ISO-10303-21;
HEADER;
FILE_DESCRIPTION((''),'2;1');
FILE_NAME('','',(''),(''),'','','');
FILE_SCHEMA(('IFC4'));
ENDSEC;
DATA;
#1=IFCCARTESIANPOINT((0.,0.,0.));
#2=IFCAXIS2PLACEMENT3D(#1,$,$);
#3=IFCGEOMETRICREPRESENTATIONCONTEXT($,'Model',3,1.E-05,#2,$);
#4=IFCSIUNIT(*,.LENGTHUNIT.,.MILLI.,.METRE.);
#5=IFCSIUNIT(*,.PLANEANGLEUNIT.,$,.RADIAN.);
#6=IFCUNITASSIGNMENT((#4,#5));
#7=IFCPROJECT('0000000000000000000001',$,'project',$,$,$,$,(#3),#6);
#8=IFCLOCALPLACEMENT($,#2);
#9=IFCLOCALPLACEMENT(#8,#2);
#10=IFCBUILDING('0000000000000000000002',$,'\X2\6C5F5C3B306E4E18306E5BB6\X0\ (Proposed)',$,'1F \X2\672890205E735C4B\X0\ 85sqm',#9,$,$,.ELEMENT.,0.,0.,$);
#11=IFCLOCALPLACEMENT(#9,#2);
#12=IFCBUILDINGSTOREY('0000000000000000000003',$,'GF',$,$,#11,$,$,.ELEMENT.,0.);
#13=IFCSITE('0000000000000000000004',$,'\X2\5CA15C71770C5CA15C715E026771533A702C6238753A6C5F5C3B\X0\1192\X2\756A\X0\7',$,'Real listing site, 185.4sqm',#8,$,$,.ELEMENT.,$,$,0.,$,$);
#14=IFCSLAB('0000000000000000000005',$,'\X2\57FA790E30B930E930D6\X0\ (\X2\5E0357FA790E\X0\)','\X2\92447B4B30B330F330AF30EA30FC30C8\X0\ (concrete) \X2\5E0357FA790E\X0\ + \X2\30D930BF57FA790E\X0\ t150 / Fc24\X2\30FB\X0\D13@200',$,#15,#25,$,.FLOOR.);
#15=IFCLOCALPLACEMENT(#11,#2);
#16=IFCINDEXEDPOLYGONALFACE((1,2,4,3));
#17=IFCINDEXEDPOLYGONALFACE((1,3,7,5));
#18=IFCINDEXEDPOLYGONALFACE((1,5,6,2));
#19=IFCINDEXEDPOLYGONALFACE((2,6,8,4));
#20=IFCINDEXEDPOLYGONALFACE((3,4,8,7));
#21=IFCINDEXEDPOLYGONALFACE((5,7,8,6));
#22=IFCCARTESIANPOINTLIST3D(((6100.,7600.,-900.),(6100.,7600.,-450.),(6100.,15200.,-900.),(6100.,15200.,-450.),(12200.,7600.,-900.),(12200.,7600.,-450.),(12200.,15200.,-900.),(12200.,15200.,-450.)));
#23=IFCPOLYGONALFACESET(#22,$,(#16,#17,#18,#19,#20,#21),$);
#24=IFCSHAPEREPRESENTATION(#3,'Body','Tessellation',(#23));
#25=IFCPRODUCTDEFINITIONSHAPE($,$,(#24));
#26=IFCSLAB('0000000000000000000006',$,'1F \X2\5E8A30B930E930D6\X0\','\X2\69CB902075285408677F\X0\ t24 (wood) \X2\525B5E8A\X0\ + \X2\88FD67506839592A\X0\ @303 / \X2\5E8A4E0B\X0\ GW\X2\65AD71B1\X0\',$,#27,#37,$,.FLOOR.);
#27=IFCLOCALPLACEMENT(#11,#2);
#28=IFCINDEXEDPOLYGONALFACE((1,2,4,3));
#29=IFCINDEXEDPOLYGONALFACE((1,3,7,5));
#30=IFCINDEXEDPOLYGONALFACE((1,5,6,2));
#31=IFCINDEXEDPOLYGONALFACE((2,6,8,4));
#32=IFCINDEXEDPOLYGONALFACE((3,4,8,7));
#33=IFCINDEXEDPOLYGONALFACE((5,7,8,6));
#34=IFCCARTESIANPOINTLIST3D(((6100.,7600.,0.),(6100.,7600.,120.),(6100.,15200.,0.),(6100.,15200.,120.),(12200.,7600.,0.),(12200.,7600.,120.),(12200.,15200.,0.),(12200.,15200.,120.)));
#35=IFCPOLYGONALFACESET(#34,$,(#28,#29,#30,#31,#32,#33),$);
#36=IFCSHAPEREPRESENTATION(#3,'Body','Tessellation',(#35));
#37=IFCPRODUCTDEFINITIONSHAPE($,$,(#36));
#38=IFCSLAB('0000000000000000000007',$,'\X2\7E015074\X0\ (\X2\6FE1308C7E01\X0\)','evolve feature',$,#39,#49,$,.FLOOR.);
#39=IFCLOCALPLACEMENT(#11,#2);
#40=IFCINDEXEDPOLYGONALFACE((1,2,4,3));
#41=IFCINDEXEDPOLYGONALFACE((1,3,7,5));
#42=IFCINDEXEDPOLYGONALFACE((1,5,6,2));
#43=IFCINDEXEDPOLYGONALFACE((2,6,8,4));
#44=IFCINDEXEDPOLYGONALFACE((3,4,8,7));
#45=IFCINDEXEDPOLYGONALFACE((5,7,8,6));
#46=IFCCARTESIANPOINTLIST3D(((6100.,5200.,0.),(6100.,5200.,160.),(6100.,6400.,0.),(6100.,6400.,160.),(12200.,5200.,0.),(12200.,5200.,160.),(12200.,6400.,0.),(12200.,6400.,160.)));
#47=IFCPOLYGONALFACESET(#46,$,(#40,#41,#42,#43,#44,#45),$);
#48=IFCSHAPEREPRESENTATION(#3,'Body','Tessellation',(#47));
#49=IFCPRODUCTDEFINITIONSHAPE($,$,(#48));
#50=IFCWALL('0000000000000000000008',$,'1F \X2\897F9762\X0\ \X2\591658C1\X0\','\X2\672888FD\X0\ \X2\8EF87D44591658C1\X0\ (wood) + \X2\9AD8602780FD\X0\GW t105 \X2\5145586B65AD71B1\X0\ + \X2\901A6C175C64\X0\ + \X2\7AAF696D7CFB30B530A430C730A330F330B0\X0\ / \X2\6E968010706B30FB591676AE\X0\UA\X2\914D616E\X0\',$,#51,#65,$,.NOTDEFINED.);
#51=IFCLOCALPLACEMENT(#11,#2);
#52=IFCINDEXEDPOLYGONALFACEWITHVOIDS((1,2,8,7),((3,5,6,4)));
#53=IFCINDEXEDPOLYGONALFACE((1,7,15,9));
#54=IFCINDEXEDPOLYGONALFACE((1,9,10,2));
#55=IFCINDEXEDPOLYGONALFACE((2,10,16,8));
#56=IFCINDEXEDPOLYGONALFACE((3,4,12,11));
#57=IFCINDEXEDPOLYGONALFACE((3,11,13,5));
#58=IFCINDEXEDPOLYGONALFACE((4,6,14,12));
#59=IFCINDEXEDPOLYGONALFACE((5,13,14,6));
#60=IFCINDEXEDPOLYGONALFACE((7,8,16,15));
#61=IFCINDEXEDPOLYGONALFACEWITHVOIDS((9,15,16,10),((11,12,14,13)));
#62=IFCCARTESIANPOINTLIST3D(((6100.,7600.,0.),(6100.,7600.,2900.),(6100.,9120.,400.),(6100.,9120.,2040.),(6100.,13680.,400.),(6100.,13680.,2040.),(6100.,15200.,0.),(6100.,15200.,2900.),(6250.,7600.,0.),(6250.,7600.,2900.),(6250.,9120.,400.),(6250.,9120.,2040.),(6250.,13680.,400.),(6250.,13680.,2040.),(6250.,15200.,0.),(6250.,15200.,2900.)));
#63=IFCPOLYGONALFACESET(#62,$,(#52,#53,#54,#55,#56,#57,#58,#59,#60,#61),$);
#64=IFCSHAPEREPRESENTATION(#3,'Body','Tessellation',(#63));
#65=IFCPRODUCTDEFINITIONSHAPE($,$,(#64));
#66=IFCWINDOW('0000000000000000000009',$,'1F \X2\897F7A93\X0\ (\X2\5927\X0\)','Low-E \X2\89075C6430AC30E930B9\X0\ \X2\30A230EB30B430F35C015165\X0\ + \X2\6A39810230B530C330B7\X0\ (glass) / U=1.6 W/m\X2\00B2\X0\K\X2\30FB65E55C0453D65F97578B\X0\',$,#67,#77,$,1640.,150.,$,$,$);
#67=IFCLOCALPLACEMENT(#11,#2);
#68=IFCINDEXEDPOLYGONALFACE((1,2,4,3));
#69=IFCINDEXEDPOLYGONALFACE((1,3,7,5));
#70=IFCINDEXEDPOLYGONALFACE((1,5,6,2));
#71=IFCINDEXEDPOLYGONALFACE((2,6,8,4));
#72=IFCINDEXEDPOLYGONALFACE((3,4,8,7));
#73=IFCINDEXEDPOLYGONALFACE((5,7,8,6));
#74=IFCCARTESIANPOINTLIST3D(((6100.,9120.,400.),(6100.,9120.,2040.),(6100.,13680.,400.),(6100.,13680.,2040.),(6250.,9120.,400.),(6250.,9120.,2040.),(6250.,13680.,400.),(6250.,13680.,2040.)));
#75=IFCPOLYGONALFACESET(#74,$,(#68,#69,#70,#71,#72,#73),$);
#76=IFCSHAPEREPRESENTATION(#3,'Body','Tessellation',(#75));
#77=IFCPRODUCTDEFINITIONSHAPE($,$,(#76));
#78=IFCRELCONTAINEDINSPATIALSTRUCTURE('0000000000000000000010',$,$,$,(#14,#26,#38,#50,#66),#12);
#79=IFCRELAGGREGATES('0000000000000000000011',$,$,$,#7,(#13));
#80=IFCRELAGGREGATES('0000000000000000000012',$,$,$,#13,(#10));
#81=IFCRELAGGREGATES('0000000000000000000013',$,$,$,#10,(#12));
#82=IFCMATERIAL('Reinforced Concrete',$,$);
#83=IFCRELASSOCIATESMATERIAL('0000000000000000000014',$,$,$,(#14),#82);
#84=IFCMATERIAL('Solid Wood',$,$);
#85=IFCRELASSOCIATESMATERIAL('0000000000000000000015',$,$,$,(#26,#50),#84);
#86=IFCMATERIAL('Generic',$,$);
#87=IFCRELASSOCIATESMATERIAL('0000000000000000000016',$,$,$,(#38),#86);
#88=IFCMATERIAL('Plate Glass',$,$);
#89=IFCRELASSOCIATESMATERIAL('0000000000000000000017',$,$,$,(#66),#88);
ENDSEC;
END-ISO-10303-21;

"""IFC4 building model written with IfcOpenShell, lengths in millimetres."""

from ifc_helpers import new_model, si_unit, frame, frame_2d, origin, place, context, project, spatial, rectangle, extrude, material, element, fill, save


model = new_model("IFC4")

# Units and contexts
model_context = context("Model", 3, precision=1e-05, world=origin())
ifc_project = project(units=[si_unit("LENGTHUNIT", "METRE", prefix="MILLI"), si_unit("PLANEANGLEUNIT", "RADIAN")], contexts=[model_context])

# Site, building, storey
site_placement = place(None, origin())
site = spatial("IfcSite", under=ifc_project, at=site_placement, Name="岡山県岡山市東区瀬戸町江尻1192番7", ObjectType="Real listing site, 185.4sqm", CompositionType="ELEMENT", RefElevation=0.0)
building_placement = place(site_placement, origin())
building = spatial("IfcBuilding", under=site, at=building_placement, Name="江尻の丘の家 (Proposed)", ObjectType="1F 木造平屋 85sqm", CompositionType="ELEMENT", ElevationOfRefHeight=0.0, ElevationOfTerrain=0.0)
storey_placement = place(building_placement, origin())
storey = spatial("IfcBuildingStorey", under=building, at=storey_placement, Name="GF", CompositionType="ELEMENT", Elevation=0.0)

# Slabs
ifc_material_1 = material(Name="Reinforced Concrete")
slab_1_placement = place(storey_placement, frame((3050.0, 3800.0, -450.0)))
element("IfcSlab", 1, at=slab_1_placement, inside=storey, material=ifc_material_1, Name="基礎スラブ (布基礎)", Description="鉄筋コンクリート (concrete) 布基礎 + ベタ基礎 t150 / Fc24・D13@200", PredefinedType="FLOOR", context=model_context, shape_type="SweptSolid", body=[
    extrude(rectangle(XDim=6100.0, YDim=7600.0, at=frame_2d((3050.0, 3800.0))), frame((3050.0, 3800.0, -450.0)), (0.0, 0.0, 1.0), 450.0),
])
ifc_material_2 = material(Name="Solid Wood")
slab_2_placement = place(storey_placement, frame((3050.0, 3800.0, 0.0)))
element("IfcSlab", 2, at=slab_2_placement, inside=storey, material=ifc_material_2, Name="1F 床スラブ", Description="構造用合板 t24 (wood) 剛床 + 製材根太 @303 / 床下 GW断熱", PredefinedType="FLOOR", context=model_context, shape_type="SweptSolid", body=[
    extrude(rectangle(XDim=6100.0, YDim=7600.0, at=frame_2d((3050.0, 3800.0))), frame((3050.0, 3800.0, 0.0)), (0.0, 0.0, 1.0), 120.0),
])
ifc_material_3 = material(Name="Generic")
slab_3_placement = place(storey_placement, frame((3050.0, 2600.0, 0.0)))
element("IfcSlab", 3, at=slab_3_placement, inside=storey, material=ifc_material_3, Name="縁側 (濡れ縁)", Description="evolve feature", PredefinedType="FLOOR", context=model_context, shape_type="SweptSolid", body=[
    extrude(rectangle(XDim=6100.0, YDim=1200.0, at=frame_2d((3050.0, 600.0))), frame((3050.0, 2600.0, 0.0)), (0.0, 0.0, 1.0), 160.0),
])

# Shared definitions
ifc_material_4 = material(Name="Plate Glass")

# Wall, opening, window
wall_1_placement = place(storey_placement, frame((3050.0, 3800.0, 0.0)))
wall_1 = element("IfcWall", 4, at=wall_1_placement, inside=storey, material=ifc_material_2, Name="1F 西面 外壁", Description="木製 軸組外壁 (wood) + 高性能GW t105 充填断熱 + 通気層 + 窯業系サイディング / 準耐火・外皮UA配慮", PredefinedType="NOTDEFINED", context=model_context, shape_type="SweptSolid", body=[
    extrude(rectangle(XDim=150.0, YDim=7600.0, at=frame_2d((75.0, 3800.0))), frame((3050.0, 3800.0, 0.0)), (0.0, 0.0, 1.0), 2900.0),
])
opening_1_placement = place(storey_placement, frame((3050.0, 4560.0, 200.0)))
opening_1 = element("IfcOpeningElement", 5, at=opening_1_placement, cuts=wall_1, PredefinedType="NOTDEFINED", context=model_context, shape_type="SweptSolid", body=[
    extrude(rectangle(XDim=150.0, YDim=4560.0, at=frame_2d((75.0, 2280.0))), frame((3050.0, 4560.0, 200.0)), (0.0, 0.0, 1.0), 1640.0),
])
window_1_placement = place(storey_placement, frame((3050.0, 4560.0, 200.0)))
window_1 = element("IfcWindow", 6, at=window_1_placement, inside=storey, material=ifc_material_4, Name="1F 西窓 (大)", Description="Low-E 複層ガラス アルゴン封入 + 樹脂サッシ (glass) / U=1.6 W/m²K・日射取得型", OverallHeight=1640.0, OverallWidth=150.0, context=model_context, shape_type="SweptSolid", body=[
    extrude(rectangle(XDim=150.0, YDim=4560.0, at=frame_2d((75.0, 2280.0))), frame((3050.0, 4560.0, 200.0)), (0.0, 0.0, 1.0), 1640.0),
])
fill(opening_1, window_1)

save(model, "model.ifc")
